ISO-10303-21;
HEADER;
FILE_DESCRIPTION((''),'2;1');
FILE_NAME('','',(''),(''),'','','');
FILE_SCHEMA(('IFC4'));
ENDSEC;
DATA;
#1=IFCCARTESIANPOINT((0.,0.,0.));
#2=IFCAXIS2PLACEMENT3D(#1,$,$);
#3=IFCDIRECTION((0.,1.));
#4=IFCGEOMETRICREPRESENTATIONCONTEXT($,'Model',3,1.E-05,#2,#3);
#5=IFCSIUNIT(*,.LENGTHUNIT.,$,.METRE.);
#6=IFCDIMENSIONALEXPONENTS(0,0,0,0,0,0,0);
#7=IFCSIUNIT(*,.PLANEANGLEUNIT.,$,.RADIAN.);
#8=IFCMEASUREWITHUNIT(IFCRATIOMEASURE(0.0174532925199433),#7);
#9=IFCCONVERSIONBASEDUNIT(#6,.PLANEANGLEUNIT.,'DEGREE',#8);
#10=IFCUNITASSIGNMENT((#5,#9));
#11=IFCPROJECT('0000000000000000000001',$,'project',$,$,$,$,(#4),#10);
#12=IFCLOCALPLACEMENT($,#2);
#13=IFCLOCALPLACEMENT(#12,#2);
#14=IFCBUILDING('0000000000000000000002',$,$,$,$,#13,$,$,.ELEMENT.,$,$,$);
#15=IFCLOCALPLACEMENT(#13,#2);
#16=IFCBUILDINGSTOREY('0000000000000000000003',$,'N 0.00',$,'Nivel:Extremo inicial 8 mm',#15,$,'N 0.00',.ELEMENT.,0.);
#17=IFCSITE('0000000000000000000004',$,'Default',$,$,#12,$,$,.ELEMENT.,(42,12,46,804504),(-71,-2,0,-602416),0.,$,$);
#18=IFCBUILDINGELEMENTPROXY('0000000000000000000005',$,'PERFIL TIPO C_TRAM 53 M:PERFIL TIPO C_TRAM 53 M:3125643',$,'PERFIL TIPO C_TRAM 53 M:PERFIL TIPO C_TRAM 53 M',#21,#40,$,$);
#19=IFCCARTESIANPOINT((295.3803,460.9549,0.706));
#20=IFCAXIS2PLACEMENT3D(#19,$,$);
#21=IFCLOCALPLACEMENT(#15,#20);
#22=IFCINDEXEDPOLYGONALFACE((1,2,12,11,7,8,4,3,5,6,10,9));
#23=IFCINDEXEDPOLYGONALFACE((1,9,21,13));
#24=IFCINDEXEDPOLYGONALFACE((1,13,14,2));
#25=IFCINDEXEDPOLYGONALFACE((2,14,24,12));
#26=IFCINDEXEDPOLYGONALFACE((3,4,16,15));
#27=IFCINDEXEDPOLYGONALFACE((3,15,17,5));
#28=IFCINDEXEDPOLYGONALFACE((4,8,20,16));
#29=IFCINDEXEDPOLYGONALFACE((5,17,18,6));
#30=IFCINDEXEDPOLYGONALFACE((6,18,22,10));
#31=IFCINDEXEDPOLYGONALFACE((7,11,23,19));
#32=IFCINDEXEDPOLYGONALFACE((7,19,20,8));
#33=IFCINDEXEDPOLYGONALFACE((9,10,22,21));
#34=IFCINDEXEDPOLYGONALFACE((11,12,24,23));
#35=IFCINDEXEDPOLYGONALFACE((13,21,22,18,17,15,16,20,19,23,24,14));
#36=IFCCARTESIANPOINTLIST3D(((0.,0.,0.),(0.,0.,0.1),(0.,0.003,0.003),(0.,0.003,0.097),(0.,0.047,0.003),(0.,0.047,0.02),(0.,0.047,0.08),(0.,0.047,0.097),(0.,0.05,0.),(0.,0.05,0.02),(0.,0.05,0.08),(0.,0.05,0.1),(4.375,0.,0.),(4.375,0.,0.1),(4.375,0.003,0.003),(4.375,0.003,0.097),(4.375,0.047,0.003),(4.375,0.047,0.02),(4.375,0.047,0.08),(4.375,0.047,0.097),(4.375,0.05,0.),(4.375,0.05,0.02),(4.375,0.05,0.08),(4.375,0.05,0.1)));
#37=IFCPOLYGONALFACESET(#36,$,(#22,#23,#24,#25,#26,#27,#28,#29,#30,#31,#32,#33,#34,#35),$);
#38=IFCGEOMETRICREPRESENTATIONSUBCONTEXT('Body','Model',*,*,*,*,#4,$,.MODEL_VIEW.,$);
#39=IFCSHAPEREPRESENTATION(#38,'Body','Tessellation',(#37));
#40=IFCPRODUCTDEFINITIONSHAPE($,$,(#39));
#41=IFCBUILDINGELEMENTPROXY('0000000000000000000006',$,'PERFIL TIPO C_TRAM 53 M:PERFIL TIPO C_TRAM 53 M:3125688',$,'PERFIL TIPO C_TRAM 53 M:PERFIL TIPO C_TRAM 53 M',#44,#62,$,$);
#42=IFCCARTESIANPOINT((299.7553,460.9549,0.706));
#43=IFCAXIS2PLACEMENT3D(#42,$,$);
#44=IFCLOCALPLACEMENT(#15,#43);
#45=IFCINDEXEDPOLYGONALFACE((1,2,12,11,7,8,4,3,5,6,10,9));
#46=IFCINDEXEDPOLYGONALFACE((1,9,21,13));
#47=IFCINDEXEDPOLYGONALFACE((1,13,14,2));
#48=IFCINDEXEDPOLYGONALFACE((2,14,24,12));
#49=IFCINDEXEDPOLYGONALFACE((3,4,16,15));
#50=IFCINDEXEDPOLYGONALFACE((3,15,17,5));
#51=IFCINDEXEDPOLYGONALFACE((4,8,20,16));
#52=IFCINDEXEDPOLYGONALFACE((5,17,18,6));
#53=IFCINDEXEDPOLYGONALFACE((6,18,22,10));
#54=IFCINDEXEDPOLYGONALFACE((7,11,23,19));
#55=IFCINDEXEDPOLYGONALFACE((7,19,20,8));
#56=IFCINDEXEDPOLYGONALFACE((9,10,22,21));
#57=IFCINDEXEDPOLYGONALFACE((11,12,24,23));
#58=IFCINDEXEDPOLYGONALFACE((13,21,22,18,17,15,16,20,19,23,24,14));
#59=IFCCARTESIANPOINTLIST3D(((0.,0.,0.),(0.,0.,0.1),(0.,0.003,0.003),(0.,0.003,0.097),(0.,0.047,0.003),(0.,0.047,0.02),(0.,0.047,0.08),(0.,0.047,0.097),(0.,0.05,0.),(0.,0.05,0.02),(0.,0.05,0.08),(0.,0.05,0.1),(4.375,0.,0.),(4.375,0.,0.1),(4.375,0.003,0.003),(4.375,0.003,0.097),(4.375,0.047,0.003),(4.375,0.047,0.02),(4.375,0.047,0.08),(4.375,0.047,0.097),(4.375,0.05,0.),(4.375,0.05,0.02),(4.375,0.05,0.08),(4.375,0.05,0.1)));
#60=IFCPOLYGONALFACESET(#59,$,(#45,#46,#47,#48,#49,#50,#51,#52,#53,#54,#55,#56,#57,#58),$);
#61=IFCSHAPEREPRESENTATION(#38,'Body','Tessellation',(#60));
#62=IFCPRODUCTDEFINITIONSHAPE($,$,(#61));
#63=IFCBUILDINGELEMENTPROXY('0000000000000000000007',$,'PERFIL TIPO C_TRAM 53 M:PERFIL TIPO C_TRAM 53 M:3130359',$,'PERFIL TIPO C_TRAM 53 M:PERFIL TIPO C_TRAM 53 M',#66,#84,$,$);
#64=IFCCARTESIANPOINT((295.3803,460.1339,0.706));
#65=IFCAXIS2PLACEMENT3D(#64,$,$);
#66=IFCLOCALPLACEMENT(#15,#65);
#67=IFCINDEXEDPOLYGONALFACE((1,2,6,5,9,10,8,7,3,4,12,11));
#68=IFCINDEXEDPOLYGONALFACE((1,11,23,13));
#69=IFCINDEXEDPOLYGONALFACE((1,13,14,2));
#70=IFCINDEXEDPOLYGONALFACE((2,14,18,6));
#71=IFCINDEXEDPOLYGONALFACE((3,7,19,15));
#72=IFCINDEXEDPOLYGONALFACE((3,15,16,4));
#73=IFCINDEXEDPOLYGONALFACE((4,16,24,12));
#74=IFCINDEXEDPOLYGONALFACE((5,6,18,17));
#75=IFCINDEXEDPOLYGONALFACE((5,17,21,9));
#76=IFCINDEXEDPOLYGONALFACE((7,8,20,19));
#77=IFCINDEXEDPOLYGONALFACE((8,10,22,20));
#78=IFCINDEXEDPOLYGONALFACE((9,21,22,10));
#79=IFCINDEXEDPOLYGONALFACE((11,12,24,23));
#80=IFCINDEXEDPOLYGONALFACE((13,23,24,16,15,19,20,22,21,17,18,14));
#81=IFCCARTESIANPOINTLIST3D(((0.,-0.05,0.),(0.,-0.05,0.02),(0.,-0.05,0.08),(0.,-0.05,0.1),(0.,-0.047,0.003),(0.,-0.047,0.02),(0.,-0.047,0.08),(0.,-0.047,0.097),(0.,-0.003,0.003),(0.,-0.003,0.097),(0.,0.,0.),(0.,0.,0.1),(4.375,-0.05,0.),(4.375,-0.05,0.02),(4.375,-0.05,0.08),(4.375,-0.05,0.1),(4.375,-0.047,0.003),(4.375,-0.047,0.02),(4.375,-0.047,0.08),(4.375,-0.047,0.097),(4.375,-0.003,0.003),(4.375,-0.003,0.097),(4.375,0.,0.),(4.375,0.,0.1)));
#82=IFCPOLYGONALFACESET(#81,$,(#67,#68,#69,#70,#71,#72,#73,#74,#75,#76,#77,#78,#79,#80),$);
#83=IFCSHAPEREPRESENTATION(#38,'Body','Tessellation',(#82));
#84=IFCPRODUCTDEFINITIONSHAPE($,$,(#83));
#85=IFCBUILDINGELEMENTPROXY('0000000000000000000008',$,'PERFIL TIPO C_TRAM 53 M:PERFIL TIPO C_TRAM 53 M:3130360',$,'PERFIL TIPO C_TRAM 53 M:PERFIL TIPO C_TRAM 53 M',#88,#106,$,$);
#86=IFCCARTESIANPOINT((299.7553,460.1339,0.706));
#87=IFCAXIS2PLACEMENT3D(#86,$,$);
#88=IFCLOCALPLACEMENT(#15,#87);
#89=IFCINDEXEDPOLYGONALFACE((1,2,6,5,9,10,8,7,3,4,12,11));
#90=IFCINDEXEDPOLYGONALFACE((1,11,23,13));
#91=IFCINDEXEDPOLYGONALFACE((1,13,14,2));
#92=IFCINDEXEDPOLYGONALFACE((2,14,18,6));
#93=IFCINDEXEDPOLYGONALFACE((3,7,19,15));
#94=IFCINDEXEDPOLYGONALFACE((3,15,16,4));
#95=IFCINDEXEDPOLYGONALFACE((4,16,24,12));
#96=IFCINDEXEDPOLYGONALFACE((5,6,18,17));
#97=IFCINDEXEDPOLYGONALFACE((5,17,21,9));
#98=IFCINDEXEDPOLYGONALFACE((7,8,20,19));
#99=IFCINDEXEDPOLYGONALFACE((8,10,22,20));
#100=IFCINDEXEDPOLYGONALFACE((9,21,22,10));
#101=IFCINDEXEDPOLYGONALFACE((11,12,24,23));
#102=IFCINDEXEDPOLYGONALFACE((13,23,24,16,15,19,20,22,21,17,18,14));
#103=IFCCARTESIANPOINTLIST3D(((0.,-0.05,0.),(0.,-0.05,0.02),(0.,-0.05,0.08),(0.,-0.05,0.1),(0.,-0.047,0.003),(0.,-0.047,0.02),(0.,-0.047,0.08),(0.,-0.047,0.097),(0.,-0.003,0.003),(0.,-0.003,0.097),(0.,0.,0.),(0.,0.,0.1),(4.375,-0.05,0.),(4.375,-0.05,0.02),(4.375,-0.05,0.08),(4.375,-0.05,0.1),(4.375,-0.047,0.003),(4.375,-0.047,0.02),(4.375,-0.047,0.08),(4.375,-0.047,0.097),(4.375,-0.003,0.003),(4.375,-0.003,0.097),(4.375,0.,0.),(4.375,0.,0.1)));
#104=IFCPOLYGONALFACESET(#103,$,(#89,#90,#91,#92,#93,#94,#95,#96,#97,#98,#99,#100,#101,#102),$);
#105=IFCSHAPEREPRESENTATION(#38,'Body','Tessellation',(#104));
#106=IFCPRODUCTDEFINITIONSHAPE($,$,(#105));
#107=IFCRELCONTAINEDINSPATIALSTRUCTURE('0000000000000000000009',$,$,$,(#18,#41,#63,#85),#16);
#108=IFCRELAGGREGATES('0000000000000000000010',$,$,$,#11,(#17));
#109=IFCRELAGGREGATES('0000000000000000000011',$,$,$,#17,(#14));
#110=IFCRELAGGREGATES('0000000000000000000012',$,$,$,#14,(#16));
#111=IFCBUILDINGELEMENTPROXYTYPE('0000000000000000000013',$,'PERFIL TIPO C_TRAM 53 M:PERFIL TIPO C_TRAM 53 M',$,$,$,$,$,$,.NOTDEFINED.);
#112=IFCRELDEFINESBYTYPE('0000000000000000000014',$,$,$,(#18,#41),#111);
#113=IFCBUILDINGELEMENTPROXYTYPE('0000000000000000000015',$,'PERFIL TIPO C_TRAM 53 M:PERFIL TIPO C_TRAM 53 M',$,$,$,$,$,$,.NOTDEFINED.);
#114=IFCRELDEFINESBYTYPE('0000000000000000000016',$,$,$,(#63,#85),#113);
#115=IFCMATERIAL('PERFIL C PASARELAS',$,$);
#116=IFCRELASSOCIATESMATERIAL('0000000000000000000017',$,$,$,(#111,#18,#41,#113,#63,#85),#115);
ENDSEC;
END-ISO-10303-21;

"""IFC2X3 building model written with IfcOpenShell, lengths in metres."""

from ifc_helpers import new_model, entity, si_unit, converted_unit, direction, frame, origin, place, context, subcontext, project, spatial, polyline, outline, extrude, source, transform, mapped, material, type_object, type_shapes, element, save


model = new_model("IFC2X3")

# Units and contexts
model_context = context("Model", 3, precision=1e-05, world=origin(), true_north=direction((0.0, 1.0)))
body_context = subcontext(model_context, "Body", "Model", "MODEL_VIEW")
ifc_project = project(units=[si_unit("LENGTHUNIT", "METRE"), converted_unit("PLANEANGLEUNIT", "DEGREE", entity("IfcRatioMeasure", 0.0174532925199433), si_unit("PLANEANGLEUNIT", "RADIAN"), dimensions=[0, 0, 0, 0, 0, 0, 0])], contexts=[model_context])

# Site, building, storey
site_placement = place(None, origin())
site = spatial("IfcSite", under=ifc_project, at=site_placement, Name="Default", CompositionType="ELEMENT", RefLatitude=(42, 12, 46, 804504), RefLongitude=(-71, -2, 0, -602416), RefElevation=0.0)
building_placement = place(site_placement, origin())
building = spatial("IfcBuilding", under=site, at=building_placement, CompositionType="ELEMENT")
storey_placement = place(building_placement, origin())
storey = spatial("IfcBuildingStorey", under=building, at=storey_placement, Name="N 0.00", ObjectType="Nivel:Extremo inicial 8 mm", LongName="N 0.00", CompositionType="ELEMENT", Elevation=0.0)

# Building element proxies
ifc_material_1 = material(Name="PERFIL C PASARELAS")
building_element_proxy_type_1 = type_object("IfcBuildingElementProxyType", Name="PERFIL TIPO C_TRAM 53 M:PERFIL TIPO C_TRAM 53 M", PredefinedType="NOTDEFINED", material=ifc_material_1)
shared_shape_1 = source(origin(), body_context, "Body", "SweptSolid", [
    extrude(outline(polyline([(-0.0172, 0.03), (-0.0142, 0.03), (-0.0142, 0.047), (0.0298, 0.047), (0.0298, -0.047), (-0.0142, -0.047), (-0.0142, -0.03), (-0.0172, -0.03), (-0.0172, -0.05), (0.0328, -0.05), (0.0328, 0.05), (-0.0172, 0.05), (-0.0172, 0.03)])), frame((0.0, 0.0328, 0.05), z_axis=(1.0, 0.0, 0.0), x_axis=(0.0, -1.0, 0.0)), (0.0, 0.0, 1.0), 4.375),
])
type_shapes(building_element_proxy_type_1, [shared_shape_1])
for number, where, name in (
    (1, (295.3803, 460.9549, 0.706), "PERFIL TIPO C_TRAM 53 M:PERFIL TIPO C_TRAM 53 M:3125643"),
    (2, (299.7553, 460.9549, 0.706), "PERFIL TIPO C_TRAM 53 M:PERFIL TIPO C_TRAM 53 M:3125688"),
):
    element("IfcBuildingElementProxy", number, at=place(storey_placement, frame(where)), inside=storey, type_object=building_element_proxy_type_1, material=ifc_material_1, Name=name, ObjectType="PERFIL TIPO C_TRAM 53 M:PERFIL TIPO C_TRAM 53 M", context=body_context, shape_type="MappedRepresentation", body=[
        mapped(shared_shape_1, transform((0.0, 0.0, 0.0), scale=1.0)),
    ])
building_element_proxy_type_2 = type_object("IfcBuildingElementProxyType", Name="PERFIL TIPO C_TRAM 53 M:PERFIL TIPO C_TRAM 53 M", PredefinedType="NOTDEFINED", material=ifc_material_1)
shared_shape_2 = source(origin(), body_context, "Body", "SweptSolid", [
    extrude(outline(polyline([(0.03, -0.0172), (0.05, -0.0172), (0.05, 0.0328), (-0.05, 0.0328), (-0.05, -0.0172), (-0.03, -0.0172), (-0.03, -0.0142), (-0.047, -0.0142), (-0.047, 0.0298), (0.047, 0.0298), (0.047, -0.0142), (0.03, -0.0142), (0.03, -0.0172)])), frame((0.0, -0.0328, 0.05), z_axis=(1.0, 0.0, 0.0), x_axis=(0.0, 0.0, -1.0)), (0.0, 0.0, 1.0), 4.375),
])
type_shapes(building_element_proxy_type_2, [shared_shape_2])
for number, where, name in (
    (3, (295.3803, 460.1339, 0.706), "PERFIL TIPO C_TRAM 53 M:PERFIL TIPO C_TRAM 53 M:3130359"),
    (4, (299.7553, 460.1339, 0.706), "PERFIL TIPO C_TRAM 53 M:PERFIL TIPO C_TRAM 53 M:3130360"),
):
    element("IfcBuildingElementProxy", number, at=place(storey_placement, frame(where)), inside=storey, type_object=building_element_proxy_type_2, material=ifc_material_1, Name=name, ObjectType="PERFIL TIPO C_TRAM 53 M:PERFIL TIPO C_TRAM 53 M", context=body_context, shape_type="MappedRepresentation", body=[
        mapped(shared_shape_2, transform((0.0, 0.0, 0.0), scale=1.0)),
    ])

save(model, "model.ifc")
